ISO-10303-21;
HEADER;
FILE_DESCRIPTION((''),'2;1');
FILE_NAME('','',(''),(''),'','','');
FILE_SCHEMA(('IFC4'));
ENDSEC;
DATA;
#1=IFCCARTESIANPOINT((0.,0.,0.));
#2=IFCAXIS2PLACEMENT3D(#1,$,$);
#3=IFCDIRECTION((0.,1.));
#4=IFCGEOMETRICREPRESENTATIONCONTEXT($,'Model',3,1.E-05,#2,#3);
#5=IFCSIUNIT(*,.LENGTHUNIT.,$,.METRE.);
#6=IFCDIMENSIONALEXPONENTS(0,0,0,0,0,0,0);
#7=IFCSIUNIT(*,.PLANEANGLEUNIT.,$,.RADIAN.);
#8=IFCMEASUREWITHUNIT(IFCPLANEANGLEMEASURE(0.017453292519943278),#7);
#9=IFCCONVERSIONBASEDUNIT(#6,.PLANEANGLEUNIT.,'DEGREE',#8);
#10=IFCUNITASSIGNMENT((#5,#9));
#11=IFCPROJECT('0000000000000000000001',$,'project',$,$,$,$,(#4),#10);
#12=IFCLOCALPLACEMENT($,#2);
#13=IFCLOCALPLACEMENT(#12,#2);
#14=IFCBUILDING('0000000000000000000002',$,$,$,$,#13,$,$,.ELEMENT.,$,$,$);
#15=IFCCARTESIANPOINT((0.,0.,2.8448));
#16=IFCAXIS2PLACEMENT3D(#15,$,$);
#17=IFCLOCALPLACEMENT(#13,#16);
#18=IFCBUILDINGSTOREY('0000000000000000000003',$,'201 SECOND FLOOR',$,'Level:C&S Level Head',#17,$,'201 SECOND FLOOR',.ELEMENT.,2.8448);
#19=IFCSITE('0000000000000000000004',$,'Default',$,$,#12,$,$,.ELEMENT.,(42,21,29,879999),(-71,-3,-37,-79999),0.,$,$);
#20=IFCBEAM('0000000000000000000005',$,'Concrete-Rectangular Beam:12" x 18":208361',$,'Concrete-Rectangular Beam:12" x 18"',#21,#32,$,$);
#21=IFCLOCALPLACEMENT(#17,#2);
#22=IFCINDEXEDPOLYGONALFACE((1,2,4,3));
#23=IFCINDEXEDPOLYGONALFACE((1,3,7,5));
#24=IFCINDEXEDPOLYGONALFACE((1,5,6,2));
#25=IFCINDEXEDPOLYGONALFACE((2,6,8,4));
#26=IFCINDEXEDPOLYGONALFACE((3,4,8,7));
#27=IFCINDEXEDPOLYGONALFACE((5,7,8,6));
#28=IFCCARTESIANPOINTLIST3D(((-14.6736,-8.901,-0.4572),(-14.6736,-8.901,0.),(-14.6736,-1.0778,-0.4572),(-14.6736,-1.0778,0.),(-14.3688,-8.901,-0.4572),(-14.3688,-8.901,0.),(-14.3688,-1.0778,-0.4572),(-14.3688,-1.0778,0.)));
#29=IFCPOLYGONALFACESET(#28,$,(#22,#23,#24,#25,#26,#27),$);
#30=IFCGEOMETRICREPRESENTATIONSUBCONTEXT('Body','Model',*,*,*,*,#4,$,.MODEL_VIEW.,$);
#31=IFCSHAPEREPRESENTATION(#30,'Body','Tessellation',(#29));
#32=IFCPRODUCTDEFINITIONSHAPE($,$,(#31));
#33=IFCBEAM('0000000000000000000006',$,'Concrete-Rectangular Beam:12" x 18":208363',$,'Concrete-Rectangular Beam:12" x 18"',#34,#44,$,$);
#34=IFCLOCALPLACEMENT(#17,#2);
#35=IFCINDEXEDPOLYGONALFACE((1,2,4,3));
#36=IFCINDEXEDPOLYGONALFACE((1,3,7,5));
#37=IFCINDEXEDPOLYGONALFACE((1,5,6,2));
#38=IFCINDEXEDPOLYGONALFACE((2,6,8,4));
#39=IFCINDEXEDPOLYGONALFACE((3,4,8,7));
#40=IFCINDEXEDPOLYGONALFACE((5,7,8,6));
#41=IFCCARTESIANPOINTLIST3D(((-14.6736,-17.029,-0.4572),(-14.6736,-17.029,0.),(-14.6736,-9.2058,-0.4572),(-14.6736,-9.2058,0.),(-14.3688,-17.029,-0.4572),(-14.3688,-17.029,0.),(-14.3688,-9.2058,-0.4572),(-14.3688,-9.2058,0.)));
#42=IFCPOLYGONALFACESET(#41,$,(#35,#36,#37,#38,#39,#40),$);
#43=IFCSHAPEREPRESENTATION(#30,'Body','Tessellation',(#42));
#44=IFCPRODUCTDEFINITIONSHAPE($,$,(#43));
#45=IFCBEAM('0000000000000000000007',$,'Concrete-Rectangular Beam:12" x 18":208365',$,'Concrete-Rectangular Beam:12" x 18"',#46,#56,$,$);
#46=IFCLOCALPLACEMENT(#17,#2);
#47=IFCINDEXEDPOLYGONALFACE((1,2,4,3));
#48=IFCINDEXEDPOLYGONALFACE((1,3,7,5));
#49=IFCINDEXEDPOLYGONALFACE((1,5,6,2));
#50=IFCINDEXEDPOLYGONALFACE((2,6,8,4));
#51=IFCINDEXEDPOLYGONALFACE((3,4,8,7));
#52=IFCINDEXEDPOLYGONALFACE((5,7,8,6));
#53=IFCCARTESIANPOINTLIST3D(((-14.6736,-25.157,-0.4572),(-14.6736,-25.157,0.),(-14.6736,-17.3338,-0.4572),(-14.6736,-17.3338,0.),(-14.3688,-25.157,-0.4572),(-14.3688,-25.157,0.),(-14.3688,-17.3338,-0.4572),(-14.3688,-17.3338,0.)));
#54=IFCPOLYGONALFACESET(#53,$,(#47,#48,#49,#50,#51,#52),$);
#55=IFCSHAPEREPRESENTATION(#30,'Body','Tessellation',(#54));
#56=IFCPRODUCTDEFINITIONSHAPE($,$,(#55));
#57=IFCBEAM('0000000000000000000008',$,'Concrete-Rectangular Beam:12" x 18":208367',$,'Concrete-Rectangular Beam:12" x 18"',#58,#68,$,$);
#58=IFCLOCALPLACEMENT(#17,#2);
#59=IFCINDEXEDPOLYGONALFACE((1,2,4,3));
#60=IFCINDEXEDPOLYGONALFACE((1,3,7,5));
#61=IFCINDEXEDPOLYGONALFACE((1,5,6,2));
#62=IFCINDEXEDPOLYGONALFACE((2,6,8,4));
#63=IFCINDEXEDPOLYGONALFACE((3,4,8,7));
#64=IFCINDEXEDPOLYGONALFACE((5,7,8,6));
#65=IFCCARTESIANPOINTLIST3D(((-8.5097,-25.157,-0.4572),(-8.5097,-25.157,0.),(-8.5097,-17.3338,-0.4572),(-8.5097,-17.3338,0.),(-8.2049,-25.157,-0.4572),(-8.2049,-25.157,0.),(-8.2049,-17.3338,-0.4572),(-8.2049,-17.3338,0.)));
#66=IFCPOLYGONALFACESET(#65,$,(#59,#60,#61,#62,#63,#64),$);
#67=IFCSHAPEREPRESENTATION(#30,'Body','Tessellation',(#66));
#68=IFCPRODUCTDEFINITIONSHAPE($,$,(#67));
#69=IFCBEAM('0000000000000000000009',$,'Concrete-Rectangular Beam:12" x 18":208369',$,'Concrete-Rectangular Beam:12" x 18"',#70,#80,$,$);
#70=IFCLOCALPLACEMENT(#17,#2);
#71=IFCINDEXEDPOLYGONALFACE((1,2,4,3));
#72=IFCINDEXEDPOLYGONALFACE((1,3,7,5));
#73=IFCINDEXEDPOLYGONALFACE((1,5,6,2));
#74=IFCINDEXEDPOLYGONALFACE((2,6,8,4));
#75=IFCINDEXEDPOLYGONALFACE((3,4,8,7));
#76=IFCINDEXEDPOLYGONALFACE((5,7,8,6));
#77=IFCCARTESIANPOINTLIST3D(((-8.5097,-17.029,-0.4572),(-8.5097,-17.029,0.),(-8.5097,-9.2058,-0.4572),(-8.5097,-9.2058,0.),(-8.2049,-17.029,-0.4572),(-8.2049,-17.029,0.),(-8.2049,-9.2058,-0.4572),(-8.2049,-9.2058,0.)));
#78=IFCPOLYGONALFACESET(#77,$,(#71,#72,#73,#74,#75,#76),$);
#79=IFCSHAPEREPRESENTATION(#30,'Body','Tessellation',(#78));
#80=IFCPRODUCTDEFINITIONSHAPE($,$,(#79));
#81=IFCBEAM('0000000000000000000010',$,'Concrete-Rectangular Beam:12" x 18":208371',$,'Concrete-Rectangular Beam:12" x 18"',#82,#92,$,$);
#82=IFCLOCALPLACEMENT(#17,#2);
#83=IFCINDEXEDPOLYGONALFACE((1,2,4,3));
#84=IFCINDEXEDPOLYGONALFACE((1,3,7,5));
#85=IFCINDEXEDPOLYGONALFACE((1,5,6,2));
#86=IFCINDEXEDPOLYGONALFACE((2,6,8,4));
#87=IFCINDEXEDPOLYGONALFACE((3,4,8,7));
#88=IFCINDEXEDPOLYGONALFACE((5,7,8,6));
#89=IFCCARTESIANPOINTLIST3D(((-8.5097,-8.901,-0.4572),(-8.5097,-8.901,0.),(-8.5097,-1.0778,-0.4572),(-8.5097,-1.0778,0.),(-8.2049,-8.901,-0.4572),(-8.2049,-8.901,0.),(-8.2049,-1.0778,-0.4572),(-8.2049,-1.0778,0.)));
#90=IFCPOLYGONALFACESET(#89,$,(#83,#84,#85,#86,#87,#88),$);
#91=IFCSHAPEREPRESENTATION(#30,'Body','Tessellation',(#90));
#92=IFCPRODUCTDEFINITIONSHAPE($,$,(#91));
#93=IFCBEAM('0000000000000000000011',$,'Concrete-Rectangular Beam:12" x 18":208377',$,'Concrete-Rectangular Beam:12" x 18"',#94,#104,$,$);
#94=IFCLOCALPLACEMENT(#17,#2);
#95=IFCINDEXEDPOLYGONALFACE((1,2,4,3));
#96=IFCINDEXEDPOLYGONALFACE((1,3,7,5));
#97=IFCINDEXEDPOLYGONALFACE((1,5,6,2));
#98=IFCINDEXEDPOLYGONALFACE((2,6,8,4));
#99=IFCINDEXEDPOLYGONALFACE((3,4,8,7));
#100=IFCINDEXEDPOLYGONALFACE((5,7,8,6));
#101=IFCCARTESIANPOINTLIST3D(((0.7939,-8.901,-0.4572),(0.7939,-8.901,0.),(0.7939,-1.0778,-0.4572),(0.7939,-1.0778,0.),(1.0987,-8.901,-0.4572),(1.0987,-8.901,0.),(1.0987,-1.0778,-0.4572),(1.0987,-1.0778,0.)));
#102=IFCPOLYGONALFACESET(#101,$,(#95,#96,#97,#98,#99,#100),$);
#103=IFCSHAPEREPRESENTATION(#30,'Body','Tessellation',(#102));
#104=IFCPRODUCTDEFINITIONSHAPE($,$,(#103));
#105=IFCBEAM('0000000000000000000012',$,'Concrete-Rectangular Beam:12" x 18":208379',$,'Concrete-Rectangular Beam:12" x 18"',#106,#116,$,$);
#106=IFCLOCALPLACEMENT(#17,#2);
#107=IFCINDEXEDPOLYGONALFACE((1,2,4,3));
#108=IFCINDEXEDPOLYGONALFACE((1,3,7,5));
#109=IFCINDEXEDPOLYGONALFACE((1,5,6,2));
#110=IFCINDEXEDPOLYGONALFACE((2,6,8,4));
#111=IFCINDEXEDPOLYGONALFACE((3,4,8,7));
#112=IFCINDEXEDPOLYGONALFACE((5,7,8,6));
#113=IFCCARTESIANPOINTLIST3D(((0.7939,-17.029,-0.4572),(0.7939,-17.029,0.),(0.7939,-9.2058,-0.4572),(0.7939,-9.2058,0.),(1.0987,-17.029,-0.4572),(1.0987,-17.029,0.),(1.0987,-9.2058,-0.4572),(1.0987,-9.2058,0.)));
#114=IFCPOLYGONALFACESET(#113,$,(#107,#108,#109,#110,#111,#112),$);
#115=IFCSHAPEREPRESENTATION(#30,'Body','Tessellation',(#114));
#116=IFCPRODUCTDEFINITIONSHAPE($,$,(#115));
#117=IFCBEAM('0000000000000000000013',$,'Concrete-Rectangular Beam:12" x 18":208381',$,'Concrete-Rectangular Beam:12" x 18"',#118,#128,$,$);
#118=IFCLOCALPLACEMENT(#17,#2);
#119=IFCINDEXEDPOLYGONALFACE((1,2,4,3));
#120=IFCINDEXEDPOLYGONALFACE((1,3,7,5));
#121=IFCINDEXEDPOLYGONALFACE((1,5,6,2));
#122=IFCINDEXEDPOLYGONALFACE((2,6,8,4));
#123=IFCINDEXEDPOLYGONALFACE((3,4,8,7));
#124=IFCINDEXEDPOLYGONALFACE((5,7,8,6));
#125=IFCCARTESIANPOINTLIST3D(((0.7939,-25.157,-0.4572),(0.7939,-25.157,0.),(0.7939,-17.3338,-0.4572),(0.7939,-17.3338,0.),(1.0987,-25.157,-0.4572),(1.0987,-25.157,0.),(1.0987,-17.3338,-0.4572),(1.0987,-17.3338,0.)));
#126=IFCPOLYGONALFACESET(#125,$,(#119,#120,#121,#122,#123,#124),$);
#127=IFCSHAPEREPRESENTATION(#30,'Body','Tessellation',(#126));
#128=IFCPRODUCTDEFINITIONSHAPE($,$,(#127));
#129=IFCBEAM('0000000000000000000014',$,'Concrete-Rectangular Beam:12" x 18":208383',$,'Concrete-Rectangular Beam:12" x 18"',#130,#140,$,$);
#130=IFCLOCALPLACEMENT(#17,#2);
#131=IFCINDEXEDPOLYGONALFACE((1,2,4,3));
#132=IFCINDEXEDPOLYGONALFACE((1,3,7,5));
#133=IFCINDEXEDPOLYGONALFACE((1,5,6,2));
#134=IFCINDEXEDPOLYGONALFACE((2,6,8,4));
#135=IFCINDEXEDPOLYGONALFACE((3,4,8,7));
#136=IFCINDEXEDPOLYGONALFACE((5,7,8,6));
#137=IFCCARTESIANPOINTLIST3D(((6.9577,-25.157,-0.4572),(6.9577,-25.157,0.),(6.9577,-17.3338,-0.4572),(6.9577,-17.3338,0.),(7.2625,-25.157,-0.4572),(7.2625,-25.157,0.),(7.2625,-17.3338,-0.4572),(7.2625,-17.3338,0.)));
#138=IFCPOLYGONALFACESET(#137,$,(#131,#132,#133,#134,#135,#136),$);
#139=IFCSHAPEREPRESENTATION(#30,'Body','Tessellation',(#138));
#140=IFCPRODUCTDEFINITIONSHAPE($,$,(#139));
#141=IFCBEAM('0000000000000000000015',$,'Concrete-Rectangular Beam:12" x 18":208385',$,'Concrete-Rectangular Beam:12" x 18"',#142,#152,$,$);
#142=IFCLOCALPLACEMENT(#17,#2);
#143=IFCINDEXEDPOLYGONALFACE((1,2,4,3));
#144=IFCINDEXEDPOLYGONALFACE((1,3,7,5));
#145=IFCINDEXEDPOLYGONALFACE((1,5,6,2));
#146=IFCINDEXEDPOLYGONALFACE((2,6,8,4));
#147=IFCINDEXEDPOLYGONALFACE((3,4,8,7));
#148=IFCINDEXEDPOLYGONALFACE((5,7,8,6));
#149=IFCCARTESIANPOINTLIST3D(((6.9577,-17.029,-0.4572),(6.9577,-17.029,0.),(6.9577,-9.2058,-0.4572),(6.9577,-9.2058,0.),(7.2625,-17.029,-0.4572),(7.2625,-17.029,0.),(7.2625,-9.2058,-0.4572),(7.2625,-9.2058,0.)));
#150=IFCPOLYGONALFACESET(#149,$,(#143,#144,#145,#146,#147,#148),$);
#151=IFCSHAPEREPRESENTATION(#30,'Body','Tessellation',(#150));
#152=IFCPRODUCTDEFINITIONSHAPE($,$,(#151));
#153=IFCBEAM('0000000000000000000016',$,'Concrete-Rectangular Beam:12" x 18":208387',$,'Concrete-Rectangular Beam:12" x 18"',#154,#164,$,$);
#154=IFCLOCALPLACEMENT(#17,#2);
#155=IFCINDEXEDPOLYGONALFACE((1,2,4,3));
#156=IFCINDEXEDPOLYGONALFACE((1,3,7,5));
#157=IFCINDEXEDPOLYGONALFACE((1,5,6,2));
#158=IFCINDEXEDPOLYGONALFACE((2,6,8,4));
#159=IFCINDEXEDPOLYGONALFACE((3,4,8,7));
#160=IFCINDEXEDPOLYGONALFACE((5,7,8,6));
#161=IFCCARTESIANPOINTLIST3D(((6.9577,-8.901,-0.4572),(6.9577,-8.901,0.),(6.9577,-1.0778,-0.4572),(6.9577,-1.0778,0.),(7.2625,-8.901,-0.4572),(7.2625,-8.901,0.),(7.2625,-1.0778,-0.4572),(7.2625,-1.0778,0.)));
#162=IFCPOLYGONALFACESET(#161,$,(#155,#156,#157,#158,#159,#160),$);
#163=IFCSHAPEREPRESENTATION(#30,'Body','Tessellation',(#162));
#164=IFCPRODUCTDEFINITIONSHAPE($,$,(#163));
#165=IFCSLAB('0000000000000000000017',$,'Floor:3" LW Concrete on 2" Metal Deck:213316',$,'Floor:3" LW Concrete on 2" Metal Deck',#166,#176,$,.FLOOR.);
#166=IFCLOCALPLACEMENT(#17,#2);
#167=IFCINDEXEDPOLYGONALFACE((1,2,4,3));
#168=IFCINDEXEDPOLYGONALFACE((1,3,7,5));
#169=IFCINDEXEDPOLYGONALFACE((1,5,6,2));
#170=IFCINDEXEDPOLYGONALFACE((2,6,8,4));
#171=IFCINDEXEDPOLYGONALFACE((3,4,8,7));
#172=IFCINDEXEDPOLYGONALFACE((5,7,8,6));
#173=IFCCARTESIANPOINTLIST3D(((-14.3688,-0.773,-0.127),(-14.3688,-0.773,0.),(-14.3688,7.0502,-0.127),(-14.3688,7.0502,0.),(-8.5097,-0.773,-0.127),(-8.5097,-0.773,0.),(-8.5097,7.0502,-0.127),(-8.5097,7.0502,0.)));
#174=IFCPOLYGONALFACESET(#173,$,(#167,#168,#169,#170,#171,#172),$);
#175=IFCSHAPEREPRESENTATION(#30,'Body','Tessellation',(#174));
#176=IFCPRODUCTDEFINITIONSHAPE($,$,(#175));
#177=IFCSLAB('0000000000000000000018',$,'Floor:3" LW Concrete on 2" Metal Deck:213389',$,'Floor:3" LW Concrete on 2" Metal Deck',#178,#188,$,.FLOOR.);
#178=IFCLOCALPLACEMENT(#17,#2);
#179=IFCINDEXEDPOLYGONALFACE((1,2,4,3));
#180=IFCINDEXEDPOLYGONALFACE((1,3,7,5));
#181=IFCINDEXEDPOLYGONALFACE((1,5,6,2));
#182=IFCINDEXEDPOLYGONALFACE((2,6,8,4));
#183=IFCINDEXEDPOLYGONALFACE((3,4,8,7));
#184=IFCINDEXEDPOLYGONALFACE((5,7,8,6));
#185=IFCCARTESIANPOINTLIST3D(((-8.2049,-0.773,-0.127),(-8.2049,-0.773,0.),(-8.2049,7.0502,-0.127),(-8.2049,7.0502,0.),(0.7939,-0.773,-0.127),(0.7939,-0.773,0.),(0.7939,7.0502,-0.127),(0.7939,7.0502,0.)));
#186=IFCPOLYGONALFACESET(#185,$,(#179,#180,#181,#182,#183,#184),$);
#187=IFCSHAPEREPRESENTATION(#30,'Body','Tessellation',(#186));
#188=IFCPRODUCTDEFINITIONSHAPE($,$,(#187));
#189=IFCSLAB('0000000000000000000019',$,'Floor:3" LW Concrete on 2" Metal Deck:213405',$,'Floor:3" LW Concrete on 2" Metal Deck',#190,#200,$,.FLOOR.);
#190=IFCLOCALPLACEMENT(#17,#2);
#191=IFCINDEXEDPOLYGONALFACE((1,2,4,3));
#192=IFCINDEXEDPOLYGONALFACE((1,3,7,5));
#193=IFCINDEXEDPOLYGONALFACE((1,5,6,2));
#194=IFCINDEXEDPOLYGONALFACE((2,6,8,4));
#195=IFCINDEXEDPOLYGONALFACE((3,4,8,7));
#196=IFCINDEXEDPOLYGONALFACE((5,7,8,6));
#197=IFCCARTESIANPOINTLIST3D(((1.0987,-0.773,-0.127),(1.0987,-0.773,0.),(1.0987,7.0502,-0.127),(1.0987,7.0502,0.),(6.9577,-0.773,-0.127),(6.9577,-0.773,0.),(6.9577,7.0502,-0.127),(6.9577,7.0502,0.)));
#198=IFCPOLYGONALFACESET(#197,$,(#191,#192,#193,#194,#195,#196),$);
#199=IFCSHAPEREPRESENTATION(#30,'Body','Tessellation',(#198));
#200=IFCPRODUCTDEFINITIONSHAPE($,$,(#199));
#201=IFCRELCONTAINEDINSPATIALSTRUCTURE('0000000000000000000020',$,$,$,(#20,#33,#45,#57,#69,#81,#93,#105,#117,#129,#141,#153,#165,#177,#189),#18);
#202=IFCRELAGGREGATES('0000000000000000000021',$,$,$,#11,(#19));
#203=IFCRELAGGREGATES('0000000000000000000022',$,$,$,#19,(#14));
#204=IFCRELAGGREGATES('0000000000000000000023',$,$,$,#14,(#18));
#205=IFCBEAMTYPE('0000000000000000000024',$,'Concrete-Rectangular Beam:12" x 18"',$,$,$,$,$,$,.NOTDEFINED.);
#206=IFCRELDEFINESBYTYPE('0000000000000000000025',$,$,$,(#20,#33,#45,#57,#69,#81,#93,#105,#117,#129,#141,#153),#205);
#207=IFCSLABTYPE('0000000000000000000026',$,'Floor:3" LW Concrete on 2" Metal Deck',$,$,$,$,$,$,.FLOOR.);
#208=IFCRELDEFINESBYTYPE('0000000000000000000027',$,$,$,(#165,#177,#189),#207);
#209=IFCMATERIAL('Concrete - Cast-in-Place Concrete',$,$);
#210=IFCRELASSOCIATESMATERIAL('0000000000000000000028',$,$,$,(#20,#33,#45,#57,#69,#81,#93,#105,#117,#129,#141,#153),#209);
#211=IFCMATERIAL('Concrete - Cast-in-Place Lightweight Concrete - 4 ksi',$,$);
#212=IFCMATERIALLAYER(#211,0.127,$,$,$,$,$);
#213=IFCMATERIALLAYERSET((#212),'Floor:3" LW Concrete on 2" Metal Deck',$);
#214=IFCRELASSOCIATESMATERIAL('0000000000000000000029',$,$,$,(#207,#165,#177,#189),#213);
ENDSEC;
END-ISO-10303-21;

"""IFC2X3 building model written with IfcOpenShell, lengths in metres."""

from ifc_helpers import new_model, entity, si_unit, converted_unit, direction, frame, frame_2d, origin, origin_2d_with_axis, place, context, subcontext, project, spatial, rectangle, extrude, material, layer, layer_set, layer_usage, type_object, element, save


model = new_model("IFC2X3")

# Units and contexts
model_context = context("Model", 3, precision=1e-05, world=origin(), true_north=direction((0.0, 1.0)))
body_context = subcontext(model_context, "Body", "Model", "MODEL_VIEW")
ifc_project = project(units=[si_unit("LENGTHUNIT", "METRE"), converted_unit("PLANEANGLEUNIT", "DEGREE", entity("IfcPlaneAngleMeasure", 0.017453292519943278), si_unit("PLANEANGLEUNIT", "RADIAN"), dimensions=[0, 0, 0, 0, 0, 0, 0])], contexts=[model_context])

# Site, building, storey
site_placement = place(None, origin())
site = spatial("IfcSite", under=ifc_project, at=site_placement, Name="Default", CompositionType="ELEMENT", RefLatitude=(42, 21, 29, 879999), RefLongitude=(-71, -3, -37, -79999), RefElevation=0.0)
building_placement = place(site_placement, origin())
building = spatial("IfcBuilding", under=site, at=building_placement, CompositionType="ELEMENT")
storey_placement = place(building_placement, frame((0.0, 0.0, 2.8448)))
storey = spatial("IfcBuildingStorey", under=building, at=storey_placement, Name="201 SECOND FLOOR", ObjectType="Level:C&S Level Head", LongName="201 SECOND FLOOR", CompositionType="ELEMENT", Elevation=2.8448)

# Beams
ifc_material_1 = material(Name="Concrete - Cast-in-Place Concrete")
beam_type = type_object("IfcBeamType", Name="Concrete-Rectangular Beam:12\" x 18\"", PredefinedType="NOTDEFINED")
beam_1_placement = place(storey_placement, frame((-14.5212, -1.0778, 0.0), z_axis=(0.0, 0.0, 1.0), x_axis=(0.0, -1.0, 0.0)))
element("IfcBeam", 1, at=beam_1_placement, inside=storey, type_object=beam_type, material=ifc_material_1, Name="Concrete-Rectangular Beam:12\" x 18\":208361", ObjectType="Concrete-Rectangular Beam:12\" x 18\"", context=body_context, shape_type="SweptSolid", body=[
    extrude(rectangle(XDim=0.4572, YDim=0.3048, at=origin_2d_with_axis()), frame((0.0, 0.0, -0.2286), z_axis=(1.0, 0.0, 0.0), x_axis=(0.0, 0.0, -1.0)), (0.0, 0.0, 1.0), 7.8232),
])
beam_2_placement = place(storey_placement, frame((-14.5212, -9.2058, 0.0), z_axis=(0.0, 0.0, 1.0), x_axis=(0.0, -1.0, 0.0)))
element("IfcBeam", 2, at=beam_2_placement, inside=storey, type_object=beam_type, material=ifc_material_1, Name="Concrete-Rectangular Beam:12\" x 18\":208363", ObjectType="Concrete-Rectangular Beam:12\" x 18\"", context=body_context, shape_type="SweptSolid", body=[
    extrude(rectangle(XDim=0.4572, YDim=0.3048, at=origin_2d_with_axis()), frame((0.0, 0.0, -0.2286), z_axis=(1.0, 0.0, 0.0), x_axis=(0.0, 0.0, -1.0)), (0.0, 0.0, 1.0), 7.8232),
])
beam_3_placement = place(storey_placement, frame((-14.5212, -17.3338, 0.0), z_axis=(0.0, 0.0, 1.0), x_axis=(0.0, -1.0, 0.0)))
element("IfcBeam", 3, at=beam_3_placement, inside=storey, type_object=beam_type, material=ifc_material_1, Name="Concrete-Rectangular Beam:12\" x 18\":208365", ObjectType="Concrete-Rectangular Beam:12\" x 18\"", context=body_context, shape_type="SweptSolid", body=[
    extrude(rectangle(XDim=0.4572, YDim=0.3048, at=origin_2d_with_axis()), frame((0.0, 0.0, -0.2286), z_axis=(1.0, 0.0, 0.0), x_axis=(0.0, 0.0, -1.0)), (0.0, 0.0, 1.0), 7.8232),
])
beam_4_placement = place(storey_placement, frame((-8.3573, -17.3338, 0.0), z_axis=(0.0, 0.0, 1.0), x_axis=(0.0, -1.0, 0.0)))
element("IfcBeam", 4, at=beam_4_placement, inside=storey, type_object=beam_type, material=ifc_material_1, Name="Concrete-Rectangular Beam:12\" x 18\":208367", ObjectType="Concrete-Rectangular Beam:12\" x 18\"", context=body_context, shape_type="SweptSolid", body=[
    extrude(rectangle(XDim=0.4572, YDim=0.3048, at=frame_2d((0.0, 0.0), x_axis=(1.0, 0.0))), frame((0.0, 0.0, -0.2286), z_axis=(1.0, 0.0, 0.0), x_axis=(0.0, 0.0, -1.0)), (0.0, 0.0, 1.0), 7.8232),
])
for number, where, z_axis, x_axis, name in (
    (5, (-8.3573, -9.2058, 0.0), (0.0, 0.0, 1.0), (0.0, -1.0, 0.0), "Concrete-Rectangular Beam:12\" x 18\":208369"),
    (6, (-8.3573, -1.0778, 0.0), (0.0, 0.0, 1.0), (0.0, -1.0, 0.0), "Concrete-Rectangular Beam:12\" x 18\":208371"),
):
    element("IfcBeam", number, at=place(storey_placement, frame(where, z_axis=z_axis, x_axis=x_axis)), inside=storey, type_object=beam_type, material=ifc_material_1, Name=name, ObjectType="Concrete-Rectangular Beam:12\" x 18\"", context=body_context, shape_type="SweptSolid", body=[
        extrude(rectangle(XDim=0.4572, YDim=0.3048, at=frame_2d((0.0, 0.0), x_axis=(1.0, 0.0))), frame((0.0, 0.0, -0.2286), z_axis=(1.0, 0.0, 0.0), x_axis=(0.0, 0.0, -1.0)), (0.0, 0.0, 1.0), 7.8232),
    ])
for number, where, z_axis, x_axis, name in (
    (7, (0.9463, -1.0778, 0.0), (0.0, 0.0, 1.0), (0.0, -1.0, 0.0), "Concrete-Rectangular Beam:12\" x 18\":208377"),
    (8, (0.9463, -9.2058, 0.0), (0.0, 0.0, 1.0), (0.0, -1.0, 0.0), "Concrete-Rectangular Beam:12\" x 18\":208379"),
    (9, (0.9463, -17.3338, 0.0), (0.0, 0.0, 1.0), (0.0, -1.0, 0.0), "Concrete-Rectangular Beam:12\" x 18\":208381"),
):
    element("IfcBeam", number, at=place(storey_placement, frame(where, z_axis=z_axis, x_axis=x_axis)), inside=storey, type_object=beam_type, material=ifc_material_1, Name=name, ObjectType="Concrete-Rectangular Beam:12\" x 18\"", context=body_context, shape_type="SweptSolid", body=[
        extrude(rectangle(XDim=0.4572, YDim=0.3048, at=origin_2d_with_axis()), frame((0.0, 0.0, -0.2286), z_axis=(1.0, 0.0, 0.0), x_axis=(0.0, 0.0, -1.0)), (0.0, 0.0, 1.0), 7.8232),
    ])
beam_5_placement = place(storey_placement, frame((7.1101, -17.3338, 0.0), z_axis=(0.0, 0.0, 1.0), x_axis=(0.0, -1.0, 0.0)))
element("IfcBeam", 10, at=beam_5_placement, inside=storey, type_object=beam_type, material=ifc_material_1, Name="Concrete-Rectangular Beam:12\" x 18\":208383", ObjectType="Concrete-Rectangular Beam:12\" x 18\"", context=body_context, shape_type="SweptSolid", body=[
    extrude(rectangle(XDim=0.4572, YDim=0.3048, at=frame_2d((0.0, 0.0), x_axis=(1.0, 0.0))), frame((0.0, 0.0, -0.2286), z_axis=(1.0, 0.0, 0.0), x_axis=(0.0, 0.0, -1.0)), (0.0, 0.0, 1.0), 7.8232),
])
for number, where, z_axis, x_axis, name in (
    (11, (7.1101, -9.2058, 0.0), (0.0, 0.0, 1.0), (0.0, -1.0, 0.0), "Concrete-Rectangular Beam:12\" x 18\":208385"),
    (12, (7.1101, -1.0778, 0.0), (0.0, 0.0, 1.0), (0.0, -1.0, 0.0), "Concrete-Rectangular Beam:12\" x 18\":208387"),
):
    element("IfcBeam", number, at=place(storey_placement, frame(where, z_axis=z_axis, x_axis=x_axis)), inside=storey, type_object=beam_type, material=ifc_material_1, Name=name, ObjectType="Concrete-Rectangular Beam:12\" x 18\"", context=body_context, shape_type="SweptSolid", body=[
        extrude(rectangle(XDim=0.4572, YDim=0.3048, at=frame_2d((0.0, 0.0), x_axis=(1.0, 0.0))), frame((0.0, 0.0, -0.2286), z_axis=(1.0, 0.0, 0.0), x_axis=(0.0, 0.0, -1.0)), (0.0, 0.0, 1.0), 7.8232),
    ])

# Slabs
ifc_material_2 = material(Name="Concrete - Cast-in-Place Lightweight Concrete - 4 ksi")
ifc_layer = layer(ifc_material_2, 0.127)
ifc_layer_set = layer_set([ifc_layer], Name="Floor:3\" LW Concrete on 2\" Metal Deck")
ifc_layer_usage_1 = layer_usage(ifc_layer_set, "AXIS3", "POSITIVE", 0.0)
slab_type = type_object("IfcSlabType", Name="Floor:3\" LW Concrete on 2\" Metal Deck", PredefinedType="FLOOR", material=ifc_layer_set)
slab_1_placement = place(storey_placement, origin())
element("IfcSlab", 13, at=slab_1_placement, inside=storey, type_object=slab_type, material=ifc_layer_usage_1, Name="Floor:3\" LW Concrete on 2\" Metal Deck:213316", ObjectType="Floor:3\" LW Concrete on 2\" Metal Deck", PredefinedType="FLOOR", context=body_context, shape_type="SweptSolid", body=[
    extrude(rectangle(XDim=7.8232, YDim=5.859, at=frame_2d((0.0, 0.0), x_axis=(1.0, 0.0))), frame((-11.4393, 3.1386, 0.0), z_axis=(0.0, 0.0, -1.0), x_axis=(0.0, 1.0, 0.0)), (0.0, 0.0, 1.0), 0.127),
])
ifc_layer_usage_2 = layer_usage(ifc_layer_set, "AXIS3", "POSITIVE", 0.0)
slab_2_placement = place(storey_placement, origin())
element("IfcSlab", 14, at=slab_2_placement, inside=storey, type_object=slab_type, material=ifc_layer_usage_2, Name="Floor:3\" LW Concrete on 2\" Metal Deck:213389", ObjectType="Floor:3\" LW Concrete on 2\" Metal Deck", PredefinedType="FLOOR", context=body_context, shape_type="SweptSolid", body=[
    extrude(rectangle(XDim=7.8232, YDim=8.9988, at=origin_2d_with_axis()), frame((-3.7055, 3.1386, 0.0), z_axis=(0.0, 0.0, -1.0), x_axis=(0.0, 1.0, 0.0)), (0.0, 0.0, 1.0), 0.127),
])
ifc_layer_usage_3 = layer_usage(ifc_layer_set, "AXIS3", "POSITIVE", 0.0)
slab_3_placement = place(storey_placement, origin())
element("IfcSlab", 15, at=slab_3_placement, inside=storey, type_object=slab_type, material=ifc_layer_usage_3, Name="Floor:3\" LW Concrete on 2\" Metal Deck:213405", ObjectType="Floor:3\" LW Concrete on 2\" Metal Deck", PredefinedType="FLOOR", context=body_context, shape_type="SweptSolid", body=[
    extrude(rectangle(XDim=7.8232, YDim=5.859, at=origin_2d_with_axis()), frame((4.0282, 3.1386, 0.0), z_axis=(0.0, 0.0, -1.0), x_axis=(0.0, 1.0, 0.0)), (0.0, 0.0, 1.0), 0.127),
])

save(model, "model.ifc")
